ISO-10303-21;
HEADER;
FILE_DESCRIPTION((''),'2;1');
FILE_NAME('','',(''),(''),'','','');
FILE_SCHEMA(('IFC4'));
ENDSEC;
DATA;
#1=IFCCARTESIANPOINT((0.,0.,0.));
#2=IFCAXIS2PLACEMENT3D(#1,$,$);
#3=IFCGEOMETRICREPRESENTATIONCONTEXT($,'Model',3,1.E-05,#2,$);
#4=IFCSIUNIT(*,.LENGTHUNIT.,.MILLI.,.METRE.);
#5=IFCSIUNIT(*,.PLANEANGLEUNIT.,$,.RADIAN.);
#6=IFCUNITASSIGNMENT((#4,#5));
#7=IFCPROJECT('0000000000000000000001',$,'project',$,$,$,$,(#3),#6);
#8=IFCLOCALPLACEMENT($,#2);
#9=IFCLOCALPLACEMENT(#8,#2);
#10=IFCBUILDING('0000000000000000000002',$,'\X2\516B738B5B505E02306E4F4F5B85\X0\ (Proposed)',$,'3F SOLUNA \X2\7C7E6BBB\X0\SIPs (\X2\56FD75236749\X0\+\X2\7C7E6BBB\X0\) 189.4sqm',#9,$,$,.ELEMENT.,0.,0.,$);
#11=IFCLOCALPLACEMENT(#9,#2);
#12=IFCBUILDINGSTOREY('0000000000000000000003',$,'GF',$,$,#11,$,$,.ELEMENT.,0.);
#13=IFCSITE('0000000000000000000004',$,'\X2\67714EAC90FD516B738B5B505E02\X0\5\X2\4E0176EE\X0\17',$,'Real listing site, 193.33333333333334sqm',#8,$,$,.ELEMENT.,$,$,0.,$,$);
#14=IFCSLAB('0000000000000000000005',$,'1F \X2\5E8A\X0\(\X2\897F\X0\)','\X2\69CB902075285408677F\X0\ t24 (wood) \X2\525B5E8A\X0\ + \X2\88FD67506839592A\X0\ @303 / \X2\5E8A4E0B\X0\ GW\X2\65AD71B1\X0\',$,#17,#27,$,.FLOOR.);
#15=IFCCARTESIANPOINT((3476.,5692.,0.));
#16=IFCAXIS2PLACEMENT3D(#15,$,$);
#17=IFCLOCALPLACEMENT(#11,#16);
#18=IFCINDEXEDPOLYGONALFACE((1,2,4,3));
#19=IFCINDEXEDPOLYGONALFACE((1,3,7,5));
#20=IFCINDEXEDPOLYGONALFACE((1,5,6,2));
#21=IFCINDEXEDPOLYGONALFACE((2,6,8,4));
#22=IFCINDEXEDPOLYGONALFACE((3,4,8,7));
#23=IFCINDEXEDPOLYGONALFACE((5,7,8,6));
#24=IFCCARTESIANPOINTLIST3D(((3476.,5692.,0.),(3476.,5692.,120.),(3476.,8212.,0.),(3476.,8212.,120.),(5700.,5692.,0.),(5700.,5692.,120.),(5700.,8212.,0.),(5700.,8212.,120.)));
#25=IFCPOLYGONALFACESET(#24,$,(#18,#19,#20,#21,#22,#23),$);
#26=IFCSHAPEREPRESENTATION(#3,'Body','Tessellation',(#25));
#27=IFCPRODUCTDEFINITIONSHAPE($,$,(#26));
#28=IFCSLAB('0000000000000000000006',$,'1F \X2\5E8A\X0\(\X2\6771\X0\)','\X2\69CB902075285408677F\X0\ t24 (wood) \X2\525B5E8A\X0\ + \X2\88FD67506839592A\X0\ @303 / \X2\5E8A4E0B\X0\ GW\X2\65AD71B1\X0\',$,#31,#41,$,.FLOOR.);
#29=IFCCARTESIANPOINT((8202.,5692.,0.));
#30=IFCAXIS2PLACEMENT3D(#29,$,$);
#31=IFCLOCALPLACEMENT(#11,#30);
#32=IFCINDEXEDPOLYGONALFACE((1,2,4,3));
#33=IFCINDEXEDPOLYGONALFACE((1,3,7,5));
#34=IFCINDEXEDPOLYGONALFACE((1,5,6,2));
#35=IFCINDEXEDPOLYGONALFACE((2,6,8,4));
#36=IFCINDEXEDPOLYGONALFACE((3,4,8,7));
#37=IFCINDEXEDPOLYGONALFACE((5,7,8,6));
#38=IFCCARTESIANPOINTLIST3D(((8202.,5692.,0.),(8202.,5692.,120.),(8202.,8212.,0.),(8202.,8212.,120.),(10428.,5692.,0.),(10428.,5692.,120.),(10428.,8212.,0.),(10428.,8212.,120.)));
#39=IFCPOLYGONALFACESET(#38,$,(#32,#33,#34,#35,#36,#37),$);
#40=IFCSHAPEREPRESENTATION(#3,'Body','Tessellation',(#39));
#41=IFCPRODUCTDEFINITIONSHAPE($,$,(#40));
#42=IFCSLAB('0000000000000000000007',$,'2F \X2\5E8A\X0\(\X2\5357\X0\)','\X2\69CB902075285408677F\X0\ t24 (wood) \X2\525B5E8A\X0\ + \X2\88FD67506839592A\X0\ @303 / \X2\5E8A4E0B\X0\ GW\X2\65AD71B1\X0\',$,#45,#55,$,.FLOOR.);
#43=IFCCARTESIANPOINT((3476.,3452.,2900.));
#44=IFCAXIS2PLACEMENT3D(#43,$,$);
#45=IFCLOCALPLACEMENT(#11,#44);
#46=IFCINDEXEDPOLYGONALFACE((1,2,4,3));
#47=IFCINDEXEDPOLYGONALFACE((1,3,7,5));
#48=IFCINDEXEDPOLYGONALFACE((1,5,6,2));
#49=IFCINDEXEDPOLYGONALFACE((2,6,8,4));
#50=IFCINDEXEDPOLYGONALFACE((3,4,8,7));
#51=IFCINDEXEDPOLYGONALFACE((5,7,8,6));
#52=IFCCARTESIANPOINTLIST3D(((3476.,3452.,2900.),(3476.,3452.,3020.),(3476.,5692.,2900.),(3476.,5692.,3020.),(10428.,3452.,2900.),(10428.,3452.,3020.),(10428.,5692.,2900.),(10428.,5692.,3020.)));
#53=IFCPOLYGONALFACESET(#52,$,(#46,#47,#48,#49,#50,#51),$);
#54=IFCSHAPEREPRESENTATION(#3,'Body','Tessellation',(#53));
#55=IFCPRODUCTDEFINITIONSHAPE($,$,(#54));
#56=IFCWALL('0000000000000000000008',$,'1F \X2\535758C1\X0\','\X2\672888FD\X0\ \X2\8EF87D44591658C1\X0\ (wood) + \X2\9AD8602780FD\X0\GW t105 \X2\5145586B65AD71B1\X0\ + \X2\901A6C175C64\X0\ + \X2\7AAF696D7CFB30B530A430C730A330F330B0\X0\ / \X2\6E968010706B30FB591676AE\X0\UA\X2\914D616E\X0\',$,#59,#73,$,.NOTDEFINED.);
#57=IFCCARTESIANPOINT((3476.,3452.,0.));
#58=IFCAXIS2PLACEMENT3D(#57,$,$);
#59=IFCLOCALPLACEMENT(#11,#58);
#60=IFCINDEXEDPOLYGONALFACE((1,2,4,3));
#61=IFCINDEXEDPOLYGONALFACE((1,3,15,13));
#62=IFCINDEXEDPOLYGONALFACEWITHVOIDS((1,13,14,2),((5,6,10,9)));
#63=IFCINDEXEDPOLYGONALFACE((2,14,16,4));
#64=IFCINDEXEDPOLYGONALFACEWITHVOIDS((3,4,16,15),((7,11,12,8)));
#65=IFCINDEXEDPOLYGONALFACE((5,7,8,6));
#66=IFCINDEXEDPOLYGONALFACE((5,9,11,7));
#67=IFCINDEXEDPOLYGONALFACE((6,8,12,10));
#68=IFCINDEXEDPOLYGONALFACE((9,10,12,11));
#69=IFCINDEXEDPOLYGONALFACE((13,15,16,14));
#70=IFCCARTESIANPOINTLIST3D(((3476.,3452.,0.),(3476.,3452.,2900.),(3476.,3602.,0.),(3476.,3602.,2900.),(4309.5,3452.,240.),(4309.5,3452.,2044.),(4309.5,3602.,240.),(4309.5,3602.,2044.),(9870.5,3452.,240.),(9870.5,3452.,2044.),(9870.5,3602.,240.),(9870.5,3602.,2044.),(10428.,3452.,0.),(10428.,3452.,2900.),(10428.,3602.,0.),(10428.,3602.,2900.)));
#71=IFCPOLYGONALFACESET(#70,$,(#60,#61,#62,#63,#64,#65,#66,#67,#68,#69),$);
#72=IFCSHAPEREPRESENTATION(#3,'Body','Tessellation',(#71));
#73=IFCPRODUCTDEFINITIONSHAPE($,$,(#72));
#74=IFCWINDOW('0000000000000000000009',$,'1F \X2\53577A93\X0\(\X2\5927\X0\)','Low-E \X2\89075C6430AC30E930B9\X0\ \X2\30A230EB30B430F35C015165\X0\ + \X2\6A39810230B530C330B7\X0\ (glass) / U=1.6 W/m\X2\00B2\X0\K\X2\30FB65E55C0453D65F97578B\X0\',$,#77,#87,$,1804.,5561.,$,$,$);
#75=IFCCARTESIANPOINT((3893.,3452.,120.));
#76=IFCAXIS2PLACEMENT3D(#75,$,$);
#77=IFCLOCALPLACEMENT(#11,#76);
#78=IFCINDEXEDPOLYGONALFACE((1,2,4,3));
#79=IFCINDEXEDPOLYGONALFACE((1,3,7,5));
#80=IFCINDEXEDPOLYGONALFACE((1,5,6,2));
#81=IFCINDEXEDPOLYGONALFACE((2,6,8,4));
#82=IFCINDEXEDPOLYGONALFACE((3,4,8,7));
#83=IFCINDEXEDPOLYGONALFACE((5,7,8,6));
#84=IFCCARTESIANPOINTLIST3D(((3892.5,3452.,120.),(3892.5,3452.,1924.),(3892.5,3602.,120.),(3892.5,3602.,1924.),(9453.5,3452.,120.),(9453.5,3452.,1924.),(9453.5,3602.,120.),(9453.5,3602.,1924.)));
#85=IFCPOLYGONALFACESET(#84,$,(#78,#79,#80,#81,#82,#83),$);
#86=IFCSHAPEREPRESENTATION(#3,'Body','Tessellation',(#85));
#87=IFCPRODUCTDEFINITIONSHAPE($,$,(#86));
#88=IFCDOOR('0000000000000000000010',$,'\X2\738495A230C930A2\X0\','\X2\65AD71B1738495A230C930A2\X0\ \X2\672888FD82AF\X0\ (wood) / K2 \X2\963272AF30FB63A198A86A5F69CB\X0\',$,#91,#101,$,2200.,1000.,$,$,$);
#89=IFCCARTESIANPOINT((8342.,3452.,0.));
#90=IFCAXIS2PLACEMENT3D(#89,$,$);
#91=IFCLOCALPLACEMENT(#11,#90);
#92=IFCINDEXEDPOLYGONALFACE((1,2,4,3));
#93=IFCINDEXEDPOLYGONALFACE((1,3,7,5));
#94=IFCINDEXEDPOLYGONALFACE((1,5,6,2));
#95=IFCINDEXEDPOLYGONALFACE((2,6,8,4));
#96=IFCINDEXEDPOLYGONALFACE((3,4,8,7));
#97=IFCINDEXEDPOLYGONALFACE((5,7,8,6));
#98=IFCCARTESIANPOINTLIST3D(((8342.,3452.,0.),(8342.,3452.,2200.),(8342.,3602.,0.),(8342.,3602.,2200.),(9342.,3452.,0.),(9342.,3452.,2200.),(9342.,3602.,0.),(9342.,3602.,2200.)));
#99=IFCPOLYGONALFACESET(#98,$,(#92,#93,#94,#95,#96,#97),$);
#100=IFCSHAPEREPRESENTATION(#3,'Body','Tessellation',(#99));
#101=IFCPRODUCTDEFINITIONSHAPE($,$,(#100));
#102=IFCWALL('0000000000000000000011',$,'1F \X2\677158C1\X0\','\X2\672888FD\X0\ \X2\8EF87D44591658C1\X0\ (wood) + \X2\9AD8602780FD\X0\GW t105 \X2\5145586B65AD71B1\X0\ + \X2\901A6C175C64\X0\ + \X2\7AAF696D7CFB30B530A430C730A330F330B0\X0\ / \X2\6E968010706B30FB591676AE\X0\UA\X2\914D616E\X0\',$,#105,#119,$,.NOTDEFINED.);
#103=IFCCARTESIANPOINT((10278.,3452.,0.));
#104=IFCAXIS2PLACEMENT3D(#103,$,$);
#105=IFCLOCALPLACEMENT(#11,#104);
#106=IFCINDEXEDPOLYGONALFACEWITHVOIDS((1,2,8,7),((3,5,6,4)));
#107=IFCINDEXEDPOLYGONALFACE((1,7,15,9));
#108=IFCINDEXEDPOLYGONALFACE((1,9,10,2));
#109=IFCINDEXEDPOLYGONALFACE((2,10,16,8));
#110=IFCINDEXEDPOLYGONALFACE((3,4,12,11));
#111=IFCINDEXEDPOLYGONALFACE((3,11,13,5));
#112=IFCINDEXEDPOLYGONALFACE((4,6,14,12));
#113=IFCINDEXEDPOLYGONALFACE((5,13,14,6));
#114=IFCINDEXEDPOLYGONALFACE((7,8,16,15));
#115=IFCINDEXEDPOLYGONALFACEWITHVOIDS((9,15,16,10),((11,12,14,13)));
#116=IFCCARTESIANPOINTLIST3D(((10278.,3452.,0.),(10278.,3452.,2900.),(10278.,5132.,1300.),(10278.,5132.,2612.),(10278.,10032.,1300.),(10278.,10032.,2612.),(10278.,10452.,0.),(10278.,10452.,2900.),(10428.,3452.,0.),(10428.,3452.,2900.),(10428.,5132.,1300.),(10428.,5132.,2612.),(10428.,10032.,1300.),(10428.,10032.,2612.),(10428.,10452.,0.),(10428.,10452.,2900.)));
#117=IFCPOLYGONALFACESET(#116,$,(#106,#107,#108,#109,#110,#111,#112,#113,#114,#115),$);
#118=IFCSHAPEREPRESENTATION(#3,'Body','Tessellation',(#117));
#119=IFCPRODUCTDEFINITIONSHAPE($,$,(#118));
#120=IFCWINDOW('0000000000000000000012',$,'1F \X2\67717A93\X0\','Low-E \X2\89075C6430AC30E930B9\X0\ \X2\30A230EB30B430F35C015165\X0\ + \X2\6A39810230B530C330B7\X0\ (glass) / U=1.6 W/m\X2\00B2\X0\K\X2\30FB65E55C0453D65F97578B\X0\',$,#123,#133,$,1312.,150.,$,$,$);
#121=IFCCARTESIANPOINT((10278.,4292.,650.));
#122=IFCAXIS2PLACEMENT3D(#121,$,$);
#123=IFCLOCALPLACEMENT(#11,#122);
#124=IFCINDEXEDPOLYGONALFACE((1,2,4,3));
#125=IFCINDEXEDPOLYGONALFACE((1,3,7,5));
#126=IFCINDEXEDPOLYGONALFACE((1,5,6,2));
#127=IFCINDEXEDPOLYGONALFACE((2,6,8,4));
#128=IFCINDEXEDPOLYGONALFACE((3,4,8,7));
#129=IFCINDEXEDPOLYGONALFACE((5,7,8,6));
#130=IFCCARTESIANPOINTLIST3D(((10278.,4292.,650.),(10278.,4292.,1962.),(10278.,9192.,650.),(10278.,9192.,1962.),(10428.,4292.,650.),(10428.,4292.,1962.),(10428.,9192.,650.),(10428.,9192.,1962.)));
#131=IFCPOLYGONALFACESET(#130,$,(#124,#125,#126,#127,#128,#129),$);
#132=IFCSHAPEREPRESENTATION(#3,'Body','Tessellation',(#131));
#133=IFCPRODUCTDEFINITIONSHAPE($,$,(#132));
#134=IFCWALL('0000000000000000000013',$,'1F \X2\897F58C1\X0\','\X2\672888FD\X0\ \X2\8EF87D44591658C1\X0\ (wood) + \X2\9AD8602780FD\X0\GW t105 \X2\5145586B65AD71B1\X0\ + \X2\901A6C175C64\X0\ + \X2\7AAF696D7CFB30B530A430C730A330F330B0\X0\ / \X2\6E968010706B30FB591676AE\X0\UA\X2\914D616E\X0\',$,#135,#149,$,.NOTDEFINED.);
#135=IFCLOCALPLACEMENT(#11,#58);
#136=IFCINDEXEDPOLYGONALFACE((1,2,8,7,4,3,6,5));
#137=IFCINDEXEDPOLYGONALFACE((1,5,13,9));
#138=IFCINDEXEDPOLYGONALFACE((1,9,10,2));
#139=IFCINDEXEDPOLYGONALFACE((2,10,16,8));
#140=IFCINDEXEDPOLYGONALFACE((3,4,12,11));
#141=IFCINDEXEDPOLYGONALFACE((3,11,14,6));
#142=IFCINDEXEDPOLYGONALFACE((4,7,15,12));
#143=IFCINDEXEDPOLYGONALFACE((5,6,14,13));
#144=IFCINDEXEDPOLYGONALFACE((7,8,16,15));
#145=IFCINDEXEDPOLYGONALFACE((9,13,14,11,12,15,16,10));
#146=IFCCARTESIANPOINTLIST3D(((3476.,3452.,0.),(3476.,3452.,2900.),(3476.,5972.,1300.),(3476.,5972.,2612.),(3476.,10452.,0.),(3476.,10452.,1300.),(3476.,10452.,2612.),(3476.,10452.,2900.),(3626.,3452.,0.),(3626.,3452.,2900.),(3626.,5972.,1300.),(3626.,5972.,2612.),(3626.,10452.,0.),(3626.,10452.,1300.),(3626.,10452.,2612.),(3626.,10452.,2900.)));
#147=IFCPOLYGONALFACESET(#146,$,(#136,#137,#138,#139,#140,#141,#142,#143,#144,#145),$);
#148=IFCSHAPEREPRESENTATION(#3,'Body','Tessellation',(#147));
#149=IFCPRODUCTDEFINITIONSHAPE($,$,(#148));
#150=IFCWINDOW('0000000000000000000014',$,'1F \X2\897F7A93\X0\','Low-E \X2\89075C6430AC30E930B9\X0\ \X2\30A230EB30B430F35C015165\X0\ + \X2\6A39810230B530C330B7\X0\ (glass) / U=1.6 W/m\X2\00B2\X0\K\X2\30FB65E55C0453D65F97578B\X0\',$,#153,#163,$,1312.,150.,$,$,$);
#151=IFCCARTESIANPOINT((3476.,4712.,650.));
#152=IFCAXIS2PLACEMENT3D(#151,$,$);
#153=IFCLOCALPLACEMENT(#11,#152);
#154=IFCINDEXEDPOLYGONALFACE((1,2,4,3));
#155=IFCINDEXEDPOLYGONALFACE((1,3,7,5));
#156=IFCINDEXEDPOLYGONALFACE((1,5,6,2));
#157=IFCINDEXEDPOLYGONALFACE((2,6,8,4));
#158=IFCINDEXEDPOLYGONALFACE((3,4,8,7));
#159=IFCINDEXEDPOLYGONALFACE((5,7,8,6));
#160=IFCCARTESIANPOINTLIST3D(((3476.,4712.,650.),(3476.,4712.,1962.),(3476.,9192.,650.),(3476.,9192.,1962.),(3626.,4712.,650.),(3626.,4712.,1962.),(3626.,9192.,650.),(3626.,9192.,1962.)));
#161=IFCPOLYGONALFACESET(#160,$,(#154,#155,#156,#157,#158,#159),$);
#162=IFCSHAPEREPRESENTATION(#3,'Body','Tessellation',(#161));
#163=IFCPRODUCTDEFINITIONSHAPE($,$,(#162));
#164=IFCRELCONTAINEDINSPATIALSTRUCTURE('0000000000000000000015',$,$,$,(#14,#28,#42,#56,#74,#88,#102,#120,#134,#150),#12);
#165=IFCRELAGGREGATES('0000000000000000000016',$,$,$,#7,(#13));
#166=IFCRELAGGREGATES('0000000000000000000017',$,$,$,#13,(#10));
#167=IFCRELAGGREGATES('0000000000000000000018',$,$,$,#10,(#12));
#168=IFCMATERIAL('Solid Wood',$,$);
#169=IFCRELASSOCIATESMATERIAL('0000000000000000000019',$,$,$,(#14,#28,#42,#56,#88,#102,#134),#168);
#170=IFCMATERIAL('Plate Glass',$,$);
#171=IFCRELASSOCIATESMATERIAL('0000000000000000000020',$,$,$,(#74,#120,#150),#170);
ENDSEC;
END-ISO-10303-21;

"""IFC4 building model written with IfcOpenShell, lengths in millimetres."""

from ifc_helpers import new_model, si_unit, frame, frame_2d, origin, place, context, project, spatial, rectangle, extrude, material, element, fill, save


model = new_model("IFC4")

# Units and contexts
model_context = context("Model", 3, precision=1e-05, world=origin())
ifc_project = project(units=[si_unit("LENGTHUNIT", "METRE", prefix="MILLI"), si_unit("PLANEANGLEUNIT", "RADIAN")], contexts=[model_context])

# Site, building, storey
site_placement = place(None, origin())
site = spatial("IfcSite", under=ifc_project, at=site_placement, Name="東京都八王子市5丁目17", ObjectType="Real listing site, 193.33333333333334sqm", CompositionType="ELEMENT", RefElevation=0.0)
building_placement = place(site_placement, origin())
building = spatial("IfcBuilding", under=site, at=building_placement, Name="八王子市の住宅 (Proposed)", ObjectType="3F SOLUNA 籾殻SIPs (国産杉+籾殻) 189.4sqm", CompositionType="ELEMENT", ElevationOfRefHeight=0.0, ElevationOfTerrain=0.0)
storey_placement = place(building_placement, origin())
storey = spatial("IfcBuildingStorey", under=building, at=storey_placement, Name="GF", CompositionType="ELEMENT", Elevation=0.0)

# Slabs
ifc_material_1 = material(Name="Solid Wood")
slab_1_placement = place(storey_placement, frame((3476.0, 5692.0, 0.0)))
element("IfcSlab", 1, at=slab_1_placement, inside=storey, material=ifc_material_1, Name="1F 床(西)", Description="構造用合板 t24 (wood) 剛床 + 製材根太 @303 / 床下 GW断熱", PredefinedType="FLOOR", context=model_context, shape_type="SweptSolid", body=[
    extrude(rectangle(XDim=2224.0, YDim=2520.0, at=frame_2d((1112.0, 1260.0))), frame((3476.0, 5692.0, 0.0)), (0.0, 0.0, 1.0), 120.0),
])
slab_2_placement = place(storey_placement, frame((8202.0, 5692.0, 0.0)))
element("IfcSlab", 2, at=slab_2_placement, inside=storey, material=ifc_material_1, Name="1F 床(東)", Description="構造用合板 t24 (wood) 剛床 + 製材根太 @303 / 床下 GW断熱", PredefinedType="FLOOR", context=model_context, shape_type="SweptSolid", body=[
    extrude(rectangle(XDim=2226.0, YDim=2520.0, at=frame_2d((1113.0, 1260.0))), frame((8202.0, 5692.0, 0.0)), (0.0, 0.0, 1.0), 120.0),
])
slab_3_placement = place(storey_placement, frame((3476.0, 3452.0, 2900.0)))
element("IfcSlab", 3, at=slab_3_placement, inside=storey, material=ifc_material_1, Name="2F 床(南)", Description="構造用合板 t24 (wood) 剛床 + 製材根太 @303 / 床下 GW断熱", PredefinedType="FLOOR", context=model_context, shape_type="SweptSolid", body=[
    extrude(rectangle(XDim=6952.0, YDim=2240.0, at=frame_2d((3476.0, 1120.0))), frame((3476.0, 3452.0, 2900.0)), (0.0, 0.0, 1.0), 120.0),
])

# Wall, openings, window, door
wall_1_placement = place(storey_placement, frame((3476.0, 3452.0, 0.0)))
wall_1 = element("IfcWall", 4, at=wall_1_placement, inside=storey, material=ifc_material_1, Name="1F 南壁", Description="木製 軸組外壁 (wood) + 高性能GW t105 充填断熱 + 通気層 + 窯業系サイディング / 準耐火・外皮UA配慮", PredefinedType="NOTDEFINED", context=model_context, shape_type="SweptSolid", body=[
    extrude(rectangle(XDim=6952.0, YDim=150.0, at=frame_2d((3476.0, 75.0))), frame((3476.0, 3452.0, 0.0)), (0.0, 0.0, 1.0), 2900.0),
])
opening_1_placement = place(storey_placement, frame((3893.0, 3452.0, 120.0)))
opening_1 = element("IfcOpeningElement", 5, at=opening_1_placement, cuts=wall_1, PredefinedType="NOTDEFINED", context=model_context, shape_type="SweptSolid", body=[
    extrude(rectangle(XDim=5561.0, YDim=150.0, at=frame_2d((2780.0, 75.0))), frame((3893.0, 3452.0, 120.0)), (0.0, 0.0, 1.0), 1804.0),
])
opening_2_placement = place(storey_placement, frame((8342.0, 3452.0, 0.0)))
opening_2 = element("IfcOpeningElement", 6, at=opening_2_placement, cuts=wall_1, PredefinedType="NOTDEFINED", context=model_context, shape_type="SweptSolid", body=[
    extrude(rectangle(XDim=1000.0, YDim=150.0, at=frame_2d((500.0, 75.0))), frame((8342.0, 3452.0, 0.0)), (0.0, 0.0, 1.0), 2200.0),
])
ifc_material_2 = material(Name="Plate Glass")
window_1_placement = place(storey_placement, frame((3893.0, 3452.0, 120.0)))
window_1 = element("IfcWindow", 7, at=window_1_placement, inside=storey, material=ifc_material_2, Name="1F 南窓(大)", Description="Low-E 複層ガラス アルゴン封入 + 樹脂サッシ (glass) / U=1.6 W/m²K・日射取得型", OverallHeight=1804.0, OverallWidth=5561.0, context=model_context, shape_type="SweptSolid", body=[
    extrude(rectangle(XDim=5561.0, YDim=150.0, at=frame_2d((2780.0, 75.0))), frame((3893.0, 3452.0, 120.0)), (0.0, 0.0, 1.0), 1804.0),
])
fill(opening_1, window_1)
door_placement = place(storey_placement, frame((8342.0, 3452.0, 0.0)))
door = element("IfcDoor", 8, at=door_placement, inside=storey, material=ifc_material_1, Name="玄関ドア", Description="断熱玄関ドア 木製芯 (wood) / K2 防犯・採風機構", OverallHeight=2200.0, OverallWidth=1000.0, context=model_context, shape_type="SweptSolid", body=[
    extrude(rectangle(XDim=1000.0, YDim=150.0, at=frame_2d((500.0, 75.0))), frame((8342.0, 3452.0, 0.0)), (0.0, 0.0, 1.0), 2200.0),
])
fill(opening_2, door)

# Walls, openings, windows
wall_2_placement = place(storey_placement, frame((10278.0, 3452.0, 0.0)))
wall_2 = element("IfcWall", 9, at=wall_2_placement, inside=storey, material=ifc_material_1, Name="1F 東壁", Description="木製 軸組外壁 (wood) + 高性能GW t105 充填断熱 + 通気層 + 窯業系サイディング / 準耐火・外皮UA配慮", PredefinedType="NOTDEFINED", context=model_context, shape_type="SweptSolid", body=[
    extrude(rectangle(XDim=150.0, YDim=7000.0, at=frame_2d((75.0, 3500.0))), frame((10278.0, 3452.0, 0.0)), (0.0, 0.0, 1.0), 2900.0),
])
opening_3_placement = place(storey_placement, frame((10278.0, 4292.0, 650.0)))
opening_3 = element("IfcOpeningElement", 10, at=opening_3_placement, cuts=wall_2, PredefinedType="NOTDEFINED", context=model_context, shape_type="SweptSolid", body=[
    extrude(rectangle(XDim=150.0, YDim=4900.0, at=frame_2d((75.0, 2450.0))), frame((10278.0, 4292.0, 650.0)), (0.0, 0.0, 1.0), 1312.0),
])
window_2_placement = place(storey_placement, frame((10278.0, 4292.0, 650.0)))
window_2 = element("IfcWindow", 11, at=window_2_placement, inside=storey, material=ifc_material_2, Name="1F 東窓", Description="Low-E 複層ガラス アルゴン封入 + 樹脂サッシ (glass) / U=1.6 W/m²K・日射取得型", OverallHeight=1312.0, OverallWidth=150.0, context=model_context, shape_type="SweptSolid", body=[
    extrude(rectangle(XDim=150.0, YDim=4900.0, at=frame_2d((75.0, 2450.0))), frame((10278.0, 4292.0, 650.0)), (0.0, 0.0, 1.0), 1312.0),
])
fill(opening_3, window_2)
wall_3_placement = place(storey_placement, frame((3476.0, 3452.0, 0.0)))
wall_3 = element("IfcWall", 12, at=wall_3_placement, inside=storey, material=ifc_material_1, Name="1F 西壁", Description="木製 軸組外壁 (wood) + 高性能GW t105 充填断熱 + 通気層 + 窯業系サイディング / 準耐火・外皮UA配慮", PredefinedType="NOTDEFINED", context=model_context, shape_type="SweptSolid", body=[
    extrude(rectangle(XDim=150.0, YDim=7000.0, at=frame_2d((75.0, 3500.0))), frame((3476.0, 3452.0, 0.0)), (0.0, 0.0, 1.0), 2900.0),
])
opening_4_placement = place(storey_placement, frame((3476.0, 4712.0, 650.0)))
opening_4 = element("IfcOpeningElement", 13, at=opening_4_placement, cuts=wall_3, PredefinedType="NOTDEFINED", context=model_context, shape_type="SweptSolid", body=[
    extrude(rectangle(XDim=150.0, YDim=4480.0, at=frame_2d((75.0, 2240.0))), frame((3476.0, 4712.0, 650.0)), (0.0, 0.0, 1.0), 1312.0),
])
window_3_placement = place(storey_placement, frame((3476.0, 4712.0, 650.0)))
window_3 = element("IfcWindow", 14, at=window_3_placement, inside=storey, material=ifc_material_2, Name="1F 西窓", Description="Low-E 複層ガラス アルゴン封入 + 樹脂サッシ (glass) / U=1.6 W/m²K・日射取得型", OverallHeight=1312.0, OverallWidth=150.0, context=model_context, shape_type="SweptSolid", body=[
    extrude(rectangle(XDim=150.0, YDim=4480.0, at=frame_2d((75.0, 2240.0))), frame((3476.0, 4712.0, 650.0)), (0.0, 0.0, 1.0), 1312.0),
])
fill(opening_4, window_3)

save(model, "model.ifc")
